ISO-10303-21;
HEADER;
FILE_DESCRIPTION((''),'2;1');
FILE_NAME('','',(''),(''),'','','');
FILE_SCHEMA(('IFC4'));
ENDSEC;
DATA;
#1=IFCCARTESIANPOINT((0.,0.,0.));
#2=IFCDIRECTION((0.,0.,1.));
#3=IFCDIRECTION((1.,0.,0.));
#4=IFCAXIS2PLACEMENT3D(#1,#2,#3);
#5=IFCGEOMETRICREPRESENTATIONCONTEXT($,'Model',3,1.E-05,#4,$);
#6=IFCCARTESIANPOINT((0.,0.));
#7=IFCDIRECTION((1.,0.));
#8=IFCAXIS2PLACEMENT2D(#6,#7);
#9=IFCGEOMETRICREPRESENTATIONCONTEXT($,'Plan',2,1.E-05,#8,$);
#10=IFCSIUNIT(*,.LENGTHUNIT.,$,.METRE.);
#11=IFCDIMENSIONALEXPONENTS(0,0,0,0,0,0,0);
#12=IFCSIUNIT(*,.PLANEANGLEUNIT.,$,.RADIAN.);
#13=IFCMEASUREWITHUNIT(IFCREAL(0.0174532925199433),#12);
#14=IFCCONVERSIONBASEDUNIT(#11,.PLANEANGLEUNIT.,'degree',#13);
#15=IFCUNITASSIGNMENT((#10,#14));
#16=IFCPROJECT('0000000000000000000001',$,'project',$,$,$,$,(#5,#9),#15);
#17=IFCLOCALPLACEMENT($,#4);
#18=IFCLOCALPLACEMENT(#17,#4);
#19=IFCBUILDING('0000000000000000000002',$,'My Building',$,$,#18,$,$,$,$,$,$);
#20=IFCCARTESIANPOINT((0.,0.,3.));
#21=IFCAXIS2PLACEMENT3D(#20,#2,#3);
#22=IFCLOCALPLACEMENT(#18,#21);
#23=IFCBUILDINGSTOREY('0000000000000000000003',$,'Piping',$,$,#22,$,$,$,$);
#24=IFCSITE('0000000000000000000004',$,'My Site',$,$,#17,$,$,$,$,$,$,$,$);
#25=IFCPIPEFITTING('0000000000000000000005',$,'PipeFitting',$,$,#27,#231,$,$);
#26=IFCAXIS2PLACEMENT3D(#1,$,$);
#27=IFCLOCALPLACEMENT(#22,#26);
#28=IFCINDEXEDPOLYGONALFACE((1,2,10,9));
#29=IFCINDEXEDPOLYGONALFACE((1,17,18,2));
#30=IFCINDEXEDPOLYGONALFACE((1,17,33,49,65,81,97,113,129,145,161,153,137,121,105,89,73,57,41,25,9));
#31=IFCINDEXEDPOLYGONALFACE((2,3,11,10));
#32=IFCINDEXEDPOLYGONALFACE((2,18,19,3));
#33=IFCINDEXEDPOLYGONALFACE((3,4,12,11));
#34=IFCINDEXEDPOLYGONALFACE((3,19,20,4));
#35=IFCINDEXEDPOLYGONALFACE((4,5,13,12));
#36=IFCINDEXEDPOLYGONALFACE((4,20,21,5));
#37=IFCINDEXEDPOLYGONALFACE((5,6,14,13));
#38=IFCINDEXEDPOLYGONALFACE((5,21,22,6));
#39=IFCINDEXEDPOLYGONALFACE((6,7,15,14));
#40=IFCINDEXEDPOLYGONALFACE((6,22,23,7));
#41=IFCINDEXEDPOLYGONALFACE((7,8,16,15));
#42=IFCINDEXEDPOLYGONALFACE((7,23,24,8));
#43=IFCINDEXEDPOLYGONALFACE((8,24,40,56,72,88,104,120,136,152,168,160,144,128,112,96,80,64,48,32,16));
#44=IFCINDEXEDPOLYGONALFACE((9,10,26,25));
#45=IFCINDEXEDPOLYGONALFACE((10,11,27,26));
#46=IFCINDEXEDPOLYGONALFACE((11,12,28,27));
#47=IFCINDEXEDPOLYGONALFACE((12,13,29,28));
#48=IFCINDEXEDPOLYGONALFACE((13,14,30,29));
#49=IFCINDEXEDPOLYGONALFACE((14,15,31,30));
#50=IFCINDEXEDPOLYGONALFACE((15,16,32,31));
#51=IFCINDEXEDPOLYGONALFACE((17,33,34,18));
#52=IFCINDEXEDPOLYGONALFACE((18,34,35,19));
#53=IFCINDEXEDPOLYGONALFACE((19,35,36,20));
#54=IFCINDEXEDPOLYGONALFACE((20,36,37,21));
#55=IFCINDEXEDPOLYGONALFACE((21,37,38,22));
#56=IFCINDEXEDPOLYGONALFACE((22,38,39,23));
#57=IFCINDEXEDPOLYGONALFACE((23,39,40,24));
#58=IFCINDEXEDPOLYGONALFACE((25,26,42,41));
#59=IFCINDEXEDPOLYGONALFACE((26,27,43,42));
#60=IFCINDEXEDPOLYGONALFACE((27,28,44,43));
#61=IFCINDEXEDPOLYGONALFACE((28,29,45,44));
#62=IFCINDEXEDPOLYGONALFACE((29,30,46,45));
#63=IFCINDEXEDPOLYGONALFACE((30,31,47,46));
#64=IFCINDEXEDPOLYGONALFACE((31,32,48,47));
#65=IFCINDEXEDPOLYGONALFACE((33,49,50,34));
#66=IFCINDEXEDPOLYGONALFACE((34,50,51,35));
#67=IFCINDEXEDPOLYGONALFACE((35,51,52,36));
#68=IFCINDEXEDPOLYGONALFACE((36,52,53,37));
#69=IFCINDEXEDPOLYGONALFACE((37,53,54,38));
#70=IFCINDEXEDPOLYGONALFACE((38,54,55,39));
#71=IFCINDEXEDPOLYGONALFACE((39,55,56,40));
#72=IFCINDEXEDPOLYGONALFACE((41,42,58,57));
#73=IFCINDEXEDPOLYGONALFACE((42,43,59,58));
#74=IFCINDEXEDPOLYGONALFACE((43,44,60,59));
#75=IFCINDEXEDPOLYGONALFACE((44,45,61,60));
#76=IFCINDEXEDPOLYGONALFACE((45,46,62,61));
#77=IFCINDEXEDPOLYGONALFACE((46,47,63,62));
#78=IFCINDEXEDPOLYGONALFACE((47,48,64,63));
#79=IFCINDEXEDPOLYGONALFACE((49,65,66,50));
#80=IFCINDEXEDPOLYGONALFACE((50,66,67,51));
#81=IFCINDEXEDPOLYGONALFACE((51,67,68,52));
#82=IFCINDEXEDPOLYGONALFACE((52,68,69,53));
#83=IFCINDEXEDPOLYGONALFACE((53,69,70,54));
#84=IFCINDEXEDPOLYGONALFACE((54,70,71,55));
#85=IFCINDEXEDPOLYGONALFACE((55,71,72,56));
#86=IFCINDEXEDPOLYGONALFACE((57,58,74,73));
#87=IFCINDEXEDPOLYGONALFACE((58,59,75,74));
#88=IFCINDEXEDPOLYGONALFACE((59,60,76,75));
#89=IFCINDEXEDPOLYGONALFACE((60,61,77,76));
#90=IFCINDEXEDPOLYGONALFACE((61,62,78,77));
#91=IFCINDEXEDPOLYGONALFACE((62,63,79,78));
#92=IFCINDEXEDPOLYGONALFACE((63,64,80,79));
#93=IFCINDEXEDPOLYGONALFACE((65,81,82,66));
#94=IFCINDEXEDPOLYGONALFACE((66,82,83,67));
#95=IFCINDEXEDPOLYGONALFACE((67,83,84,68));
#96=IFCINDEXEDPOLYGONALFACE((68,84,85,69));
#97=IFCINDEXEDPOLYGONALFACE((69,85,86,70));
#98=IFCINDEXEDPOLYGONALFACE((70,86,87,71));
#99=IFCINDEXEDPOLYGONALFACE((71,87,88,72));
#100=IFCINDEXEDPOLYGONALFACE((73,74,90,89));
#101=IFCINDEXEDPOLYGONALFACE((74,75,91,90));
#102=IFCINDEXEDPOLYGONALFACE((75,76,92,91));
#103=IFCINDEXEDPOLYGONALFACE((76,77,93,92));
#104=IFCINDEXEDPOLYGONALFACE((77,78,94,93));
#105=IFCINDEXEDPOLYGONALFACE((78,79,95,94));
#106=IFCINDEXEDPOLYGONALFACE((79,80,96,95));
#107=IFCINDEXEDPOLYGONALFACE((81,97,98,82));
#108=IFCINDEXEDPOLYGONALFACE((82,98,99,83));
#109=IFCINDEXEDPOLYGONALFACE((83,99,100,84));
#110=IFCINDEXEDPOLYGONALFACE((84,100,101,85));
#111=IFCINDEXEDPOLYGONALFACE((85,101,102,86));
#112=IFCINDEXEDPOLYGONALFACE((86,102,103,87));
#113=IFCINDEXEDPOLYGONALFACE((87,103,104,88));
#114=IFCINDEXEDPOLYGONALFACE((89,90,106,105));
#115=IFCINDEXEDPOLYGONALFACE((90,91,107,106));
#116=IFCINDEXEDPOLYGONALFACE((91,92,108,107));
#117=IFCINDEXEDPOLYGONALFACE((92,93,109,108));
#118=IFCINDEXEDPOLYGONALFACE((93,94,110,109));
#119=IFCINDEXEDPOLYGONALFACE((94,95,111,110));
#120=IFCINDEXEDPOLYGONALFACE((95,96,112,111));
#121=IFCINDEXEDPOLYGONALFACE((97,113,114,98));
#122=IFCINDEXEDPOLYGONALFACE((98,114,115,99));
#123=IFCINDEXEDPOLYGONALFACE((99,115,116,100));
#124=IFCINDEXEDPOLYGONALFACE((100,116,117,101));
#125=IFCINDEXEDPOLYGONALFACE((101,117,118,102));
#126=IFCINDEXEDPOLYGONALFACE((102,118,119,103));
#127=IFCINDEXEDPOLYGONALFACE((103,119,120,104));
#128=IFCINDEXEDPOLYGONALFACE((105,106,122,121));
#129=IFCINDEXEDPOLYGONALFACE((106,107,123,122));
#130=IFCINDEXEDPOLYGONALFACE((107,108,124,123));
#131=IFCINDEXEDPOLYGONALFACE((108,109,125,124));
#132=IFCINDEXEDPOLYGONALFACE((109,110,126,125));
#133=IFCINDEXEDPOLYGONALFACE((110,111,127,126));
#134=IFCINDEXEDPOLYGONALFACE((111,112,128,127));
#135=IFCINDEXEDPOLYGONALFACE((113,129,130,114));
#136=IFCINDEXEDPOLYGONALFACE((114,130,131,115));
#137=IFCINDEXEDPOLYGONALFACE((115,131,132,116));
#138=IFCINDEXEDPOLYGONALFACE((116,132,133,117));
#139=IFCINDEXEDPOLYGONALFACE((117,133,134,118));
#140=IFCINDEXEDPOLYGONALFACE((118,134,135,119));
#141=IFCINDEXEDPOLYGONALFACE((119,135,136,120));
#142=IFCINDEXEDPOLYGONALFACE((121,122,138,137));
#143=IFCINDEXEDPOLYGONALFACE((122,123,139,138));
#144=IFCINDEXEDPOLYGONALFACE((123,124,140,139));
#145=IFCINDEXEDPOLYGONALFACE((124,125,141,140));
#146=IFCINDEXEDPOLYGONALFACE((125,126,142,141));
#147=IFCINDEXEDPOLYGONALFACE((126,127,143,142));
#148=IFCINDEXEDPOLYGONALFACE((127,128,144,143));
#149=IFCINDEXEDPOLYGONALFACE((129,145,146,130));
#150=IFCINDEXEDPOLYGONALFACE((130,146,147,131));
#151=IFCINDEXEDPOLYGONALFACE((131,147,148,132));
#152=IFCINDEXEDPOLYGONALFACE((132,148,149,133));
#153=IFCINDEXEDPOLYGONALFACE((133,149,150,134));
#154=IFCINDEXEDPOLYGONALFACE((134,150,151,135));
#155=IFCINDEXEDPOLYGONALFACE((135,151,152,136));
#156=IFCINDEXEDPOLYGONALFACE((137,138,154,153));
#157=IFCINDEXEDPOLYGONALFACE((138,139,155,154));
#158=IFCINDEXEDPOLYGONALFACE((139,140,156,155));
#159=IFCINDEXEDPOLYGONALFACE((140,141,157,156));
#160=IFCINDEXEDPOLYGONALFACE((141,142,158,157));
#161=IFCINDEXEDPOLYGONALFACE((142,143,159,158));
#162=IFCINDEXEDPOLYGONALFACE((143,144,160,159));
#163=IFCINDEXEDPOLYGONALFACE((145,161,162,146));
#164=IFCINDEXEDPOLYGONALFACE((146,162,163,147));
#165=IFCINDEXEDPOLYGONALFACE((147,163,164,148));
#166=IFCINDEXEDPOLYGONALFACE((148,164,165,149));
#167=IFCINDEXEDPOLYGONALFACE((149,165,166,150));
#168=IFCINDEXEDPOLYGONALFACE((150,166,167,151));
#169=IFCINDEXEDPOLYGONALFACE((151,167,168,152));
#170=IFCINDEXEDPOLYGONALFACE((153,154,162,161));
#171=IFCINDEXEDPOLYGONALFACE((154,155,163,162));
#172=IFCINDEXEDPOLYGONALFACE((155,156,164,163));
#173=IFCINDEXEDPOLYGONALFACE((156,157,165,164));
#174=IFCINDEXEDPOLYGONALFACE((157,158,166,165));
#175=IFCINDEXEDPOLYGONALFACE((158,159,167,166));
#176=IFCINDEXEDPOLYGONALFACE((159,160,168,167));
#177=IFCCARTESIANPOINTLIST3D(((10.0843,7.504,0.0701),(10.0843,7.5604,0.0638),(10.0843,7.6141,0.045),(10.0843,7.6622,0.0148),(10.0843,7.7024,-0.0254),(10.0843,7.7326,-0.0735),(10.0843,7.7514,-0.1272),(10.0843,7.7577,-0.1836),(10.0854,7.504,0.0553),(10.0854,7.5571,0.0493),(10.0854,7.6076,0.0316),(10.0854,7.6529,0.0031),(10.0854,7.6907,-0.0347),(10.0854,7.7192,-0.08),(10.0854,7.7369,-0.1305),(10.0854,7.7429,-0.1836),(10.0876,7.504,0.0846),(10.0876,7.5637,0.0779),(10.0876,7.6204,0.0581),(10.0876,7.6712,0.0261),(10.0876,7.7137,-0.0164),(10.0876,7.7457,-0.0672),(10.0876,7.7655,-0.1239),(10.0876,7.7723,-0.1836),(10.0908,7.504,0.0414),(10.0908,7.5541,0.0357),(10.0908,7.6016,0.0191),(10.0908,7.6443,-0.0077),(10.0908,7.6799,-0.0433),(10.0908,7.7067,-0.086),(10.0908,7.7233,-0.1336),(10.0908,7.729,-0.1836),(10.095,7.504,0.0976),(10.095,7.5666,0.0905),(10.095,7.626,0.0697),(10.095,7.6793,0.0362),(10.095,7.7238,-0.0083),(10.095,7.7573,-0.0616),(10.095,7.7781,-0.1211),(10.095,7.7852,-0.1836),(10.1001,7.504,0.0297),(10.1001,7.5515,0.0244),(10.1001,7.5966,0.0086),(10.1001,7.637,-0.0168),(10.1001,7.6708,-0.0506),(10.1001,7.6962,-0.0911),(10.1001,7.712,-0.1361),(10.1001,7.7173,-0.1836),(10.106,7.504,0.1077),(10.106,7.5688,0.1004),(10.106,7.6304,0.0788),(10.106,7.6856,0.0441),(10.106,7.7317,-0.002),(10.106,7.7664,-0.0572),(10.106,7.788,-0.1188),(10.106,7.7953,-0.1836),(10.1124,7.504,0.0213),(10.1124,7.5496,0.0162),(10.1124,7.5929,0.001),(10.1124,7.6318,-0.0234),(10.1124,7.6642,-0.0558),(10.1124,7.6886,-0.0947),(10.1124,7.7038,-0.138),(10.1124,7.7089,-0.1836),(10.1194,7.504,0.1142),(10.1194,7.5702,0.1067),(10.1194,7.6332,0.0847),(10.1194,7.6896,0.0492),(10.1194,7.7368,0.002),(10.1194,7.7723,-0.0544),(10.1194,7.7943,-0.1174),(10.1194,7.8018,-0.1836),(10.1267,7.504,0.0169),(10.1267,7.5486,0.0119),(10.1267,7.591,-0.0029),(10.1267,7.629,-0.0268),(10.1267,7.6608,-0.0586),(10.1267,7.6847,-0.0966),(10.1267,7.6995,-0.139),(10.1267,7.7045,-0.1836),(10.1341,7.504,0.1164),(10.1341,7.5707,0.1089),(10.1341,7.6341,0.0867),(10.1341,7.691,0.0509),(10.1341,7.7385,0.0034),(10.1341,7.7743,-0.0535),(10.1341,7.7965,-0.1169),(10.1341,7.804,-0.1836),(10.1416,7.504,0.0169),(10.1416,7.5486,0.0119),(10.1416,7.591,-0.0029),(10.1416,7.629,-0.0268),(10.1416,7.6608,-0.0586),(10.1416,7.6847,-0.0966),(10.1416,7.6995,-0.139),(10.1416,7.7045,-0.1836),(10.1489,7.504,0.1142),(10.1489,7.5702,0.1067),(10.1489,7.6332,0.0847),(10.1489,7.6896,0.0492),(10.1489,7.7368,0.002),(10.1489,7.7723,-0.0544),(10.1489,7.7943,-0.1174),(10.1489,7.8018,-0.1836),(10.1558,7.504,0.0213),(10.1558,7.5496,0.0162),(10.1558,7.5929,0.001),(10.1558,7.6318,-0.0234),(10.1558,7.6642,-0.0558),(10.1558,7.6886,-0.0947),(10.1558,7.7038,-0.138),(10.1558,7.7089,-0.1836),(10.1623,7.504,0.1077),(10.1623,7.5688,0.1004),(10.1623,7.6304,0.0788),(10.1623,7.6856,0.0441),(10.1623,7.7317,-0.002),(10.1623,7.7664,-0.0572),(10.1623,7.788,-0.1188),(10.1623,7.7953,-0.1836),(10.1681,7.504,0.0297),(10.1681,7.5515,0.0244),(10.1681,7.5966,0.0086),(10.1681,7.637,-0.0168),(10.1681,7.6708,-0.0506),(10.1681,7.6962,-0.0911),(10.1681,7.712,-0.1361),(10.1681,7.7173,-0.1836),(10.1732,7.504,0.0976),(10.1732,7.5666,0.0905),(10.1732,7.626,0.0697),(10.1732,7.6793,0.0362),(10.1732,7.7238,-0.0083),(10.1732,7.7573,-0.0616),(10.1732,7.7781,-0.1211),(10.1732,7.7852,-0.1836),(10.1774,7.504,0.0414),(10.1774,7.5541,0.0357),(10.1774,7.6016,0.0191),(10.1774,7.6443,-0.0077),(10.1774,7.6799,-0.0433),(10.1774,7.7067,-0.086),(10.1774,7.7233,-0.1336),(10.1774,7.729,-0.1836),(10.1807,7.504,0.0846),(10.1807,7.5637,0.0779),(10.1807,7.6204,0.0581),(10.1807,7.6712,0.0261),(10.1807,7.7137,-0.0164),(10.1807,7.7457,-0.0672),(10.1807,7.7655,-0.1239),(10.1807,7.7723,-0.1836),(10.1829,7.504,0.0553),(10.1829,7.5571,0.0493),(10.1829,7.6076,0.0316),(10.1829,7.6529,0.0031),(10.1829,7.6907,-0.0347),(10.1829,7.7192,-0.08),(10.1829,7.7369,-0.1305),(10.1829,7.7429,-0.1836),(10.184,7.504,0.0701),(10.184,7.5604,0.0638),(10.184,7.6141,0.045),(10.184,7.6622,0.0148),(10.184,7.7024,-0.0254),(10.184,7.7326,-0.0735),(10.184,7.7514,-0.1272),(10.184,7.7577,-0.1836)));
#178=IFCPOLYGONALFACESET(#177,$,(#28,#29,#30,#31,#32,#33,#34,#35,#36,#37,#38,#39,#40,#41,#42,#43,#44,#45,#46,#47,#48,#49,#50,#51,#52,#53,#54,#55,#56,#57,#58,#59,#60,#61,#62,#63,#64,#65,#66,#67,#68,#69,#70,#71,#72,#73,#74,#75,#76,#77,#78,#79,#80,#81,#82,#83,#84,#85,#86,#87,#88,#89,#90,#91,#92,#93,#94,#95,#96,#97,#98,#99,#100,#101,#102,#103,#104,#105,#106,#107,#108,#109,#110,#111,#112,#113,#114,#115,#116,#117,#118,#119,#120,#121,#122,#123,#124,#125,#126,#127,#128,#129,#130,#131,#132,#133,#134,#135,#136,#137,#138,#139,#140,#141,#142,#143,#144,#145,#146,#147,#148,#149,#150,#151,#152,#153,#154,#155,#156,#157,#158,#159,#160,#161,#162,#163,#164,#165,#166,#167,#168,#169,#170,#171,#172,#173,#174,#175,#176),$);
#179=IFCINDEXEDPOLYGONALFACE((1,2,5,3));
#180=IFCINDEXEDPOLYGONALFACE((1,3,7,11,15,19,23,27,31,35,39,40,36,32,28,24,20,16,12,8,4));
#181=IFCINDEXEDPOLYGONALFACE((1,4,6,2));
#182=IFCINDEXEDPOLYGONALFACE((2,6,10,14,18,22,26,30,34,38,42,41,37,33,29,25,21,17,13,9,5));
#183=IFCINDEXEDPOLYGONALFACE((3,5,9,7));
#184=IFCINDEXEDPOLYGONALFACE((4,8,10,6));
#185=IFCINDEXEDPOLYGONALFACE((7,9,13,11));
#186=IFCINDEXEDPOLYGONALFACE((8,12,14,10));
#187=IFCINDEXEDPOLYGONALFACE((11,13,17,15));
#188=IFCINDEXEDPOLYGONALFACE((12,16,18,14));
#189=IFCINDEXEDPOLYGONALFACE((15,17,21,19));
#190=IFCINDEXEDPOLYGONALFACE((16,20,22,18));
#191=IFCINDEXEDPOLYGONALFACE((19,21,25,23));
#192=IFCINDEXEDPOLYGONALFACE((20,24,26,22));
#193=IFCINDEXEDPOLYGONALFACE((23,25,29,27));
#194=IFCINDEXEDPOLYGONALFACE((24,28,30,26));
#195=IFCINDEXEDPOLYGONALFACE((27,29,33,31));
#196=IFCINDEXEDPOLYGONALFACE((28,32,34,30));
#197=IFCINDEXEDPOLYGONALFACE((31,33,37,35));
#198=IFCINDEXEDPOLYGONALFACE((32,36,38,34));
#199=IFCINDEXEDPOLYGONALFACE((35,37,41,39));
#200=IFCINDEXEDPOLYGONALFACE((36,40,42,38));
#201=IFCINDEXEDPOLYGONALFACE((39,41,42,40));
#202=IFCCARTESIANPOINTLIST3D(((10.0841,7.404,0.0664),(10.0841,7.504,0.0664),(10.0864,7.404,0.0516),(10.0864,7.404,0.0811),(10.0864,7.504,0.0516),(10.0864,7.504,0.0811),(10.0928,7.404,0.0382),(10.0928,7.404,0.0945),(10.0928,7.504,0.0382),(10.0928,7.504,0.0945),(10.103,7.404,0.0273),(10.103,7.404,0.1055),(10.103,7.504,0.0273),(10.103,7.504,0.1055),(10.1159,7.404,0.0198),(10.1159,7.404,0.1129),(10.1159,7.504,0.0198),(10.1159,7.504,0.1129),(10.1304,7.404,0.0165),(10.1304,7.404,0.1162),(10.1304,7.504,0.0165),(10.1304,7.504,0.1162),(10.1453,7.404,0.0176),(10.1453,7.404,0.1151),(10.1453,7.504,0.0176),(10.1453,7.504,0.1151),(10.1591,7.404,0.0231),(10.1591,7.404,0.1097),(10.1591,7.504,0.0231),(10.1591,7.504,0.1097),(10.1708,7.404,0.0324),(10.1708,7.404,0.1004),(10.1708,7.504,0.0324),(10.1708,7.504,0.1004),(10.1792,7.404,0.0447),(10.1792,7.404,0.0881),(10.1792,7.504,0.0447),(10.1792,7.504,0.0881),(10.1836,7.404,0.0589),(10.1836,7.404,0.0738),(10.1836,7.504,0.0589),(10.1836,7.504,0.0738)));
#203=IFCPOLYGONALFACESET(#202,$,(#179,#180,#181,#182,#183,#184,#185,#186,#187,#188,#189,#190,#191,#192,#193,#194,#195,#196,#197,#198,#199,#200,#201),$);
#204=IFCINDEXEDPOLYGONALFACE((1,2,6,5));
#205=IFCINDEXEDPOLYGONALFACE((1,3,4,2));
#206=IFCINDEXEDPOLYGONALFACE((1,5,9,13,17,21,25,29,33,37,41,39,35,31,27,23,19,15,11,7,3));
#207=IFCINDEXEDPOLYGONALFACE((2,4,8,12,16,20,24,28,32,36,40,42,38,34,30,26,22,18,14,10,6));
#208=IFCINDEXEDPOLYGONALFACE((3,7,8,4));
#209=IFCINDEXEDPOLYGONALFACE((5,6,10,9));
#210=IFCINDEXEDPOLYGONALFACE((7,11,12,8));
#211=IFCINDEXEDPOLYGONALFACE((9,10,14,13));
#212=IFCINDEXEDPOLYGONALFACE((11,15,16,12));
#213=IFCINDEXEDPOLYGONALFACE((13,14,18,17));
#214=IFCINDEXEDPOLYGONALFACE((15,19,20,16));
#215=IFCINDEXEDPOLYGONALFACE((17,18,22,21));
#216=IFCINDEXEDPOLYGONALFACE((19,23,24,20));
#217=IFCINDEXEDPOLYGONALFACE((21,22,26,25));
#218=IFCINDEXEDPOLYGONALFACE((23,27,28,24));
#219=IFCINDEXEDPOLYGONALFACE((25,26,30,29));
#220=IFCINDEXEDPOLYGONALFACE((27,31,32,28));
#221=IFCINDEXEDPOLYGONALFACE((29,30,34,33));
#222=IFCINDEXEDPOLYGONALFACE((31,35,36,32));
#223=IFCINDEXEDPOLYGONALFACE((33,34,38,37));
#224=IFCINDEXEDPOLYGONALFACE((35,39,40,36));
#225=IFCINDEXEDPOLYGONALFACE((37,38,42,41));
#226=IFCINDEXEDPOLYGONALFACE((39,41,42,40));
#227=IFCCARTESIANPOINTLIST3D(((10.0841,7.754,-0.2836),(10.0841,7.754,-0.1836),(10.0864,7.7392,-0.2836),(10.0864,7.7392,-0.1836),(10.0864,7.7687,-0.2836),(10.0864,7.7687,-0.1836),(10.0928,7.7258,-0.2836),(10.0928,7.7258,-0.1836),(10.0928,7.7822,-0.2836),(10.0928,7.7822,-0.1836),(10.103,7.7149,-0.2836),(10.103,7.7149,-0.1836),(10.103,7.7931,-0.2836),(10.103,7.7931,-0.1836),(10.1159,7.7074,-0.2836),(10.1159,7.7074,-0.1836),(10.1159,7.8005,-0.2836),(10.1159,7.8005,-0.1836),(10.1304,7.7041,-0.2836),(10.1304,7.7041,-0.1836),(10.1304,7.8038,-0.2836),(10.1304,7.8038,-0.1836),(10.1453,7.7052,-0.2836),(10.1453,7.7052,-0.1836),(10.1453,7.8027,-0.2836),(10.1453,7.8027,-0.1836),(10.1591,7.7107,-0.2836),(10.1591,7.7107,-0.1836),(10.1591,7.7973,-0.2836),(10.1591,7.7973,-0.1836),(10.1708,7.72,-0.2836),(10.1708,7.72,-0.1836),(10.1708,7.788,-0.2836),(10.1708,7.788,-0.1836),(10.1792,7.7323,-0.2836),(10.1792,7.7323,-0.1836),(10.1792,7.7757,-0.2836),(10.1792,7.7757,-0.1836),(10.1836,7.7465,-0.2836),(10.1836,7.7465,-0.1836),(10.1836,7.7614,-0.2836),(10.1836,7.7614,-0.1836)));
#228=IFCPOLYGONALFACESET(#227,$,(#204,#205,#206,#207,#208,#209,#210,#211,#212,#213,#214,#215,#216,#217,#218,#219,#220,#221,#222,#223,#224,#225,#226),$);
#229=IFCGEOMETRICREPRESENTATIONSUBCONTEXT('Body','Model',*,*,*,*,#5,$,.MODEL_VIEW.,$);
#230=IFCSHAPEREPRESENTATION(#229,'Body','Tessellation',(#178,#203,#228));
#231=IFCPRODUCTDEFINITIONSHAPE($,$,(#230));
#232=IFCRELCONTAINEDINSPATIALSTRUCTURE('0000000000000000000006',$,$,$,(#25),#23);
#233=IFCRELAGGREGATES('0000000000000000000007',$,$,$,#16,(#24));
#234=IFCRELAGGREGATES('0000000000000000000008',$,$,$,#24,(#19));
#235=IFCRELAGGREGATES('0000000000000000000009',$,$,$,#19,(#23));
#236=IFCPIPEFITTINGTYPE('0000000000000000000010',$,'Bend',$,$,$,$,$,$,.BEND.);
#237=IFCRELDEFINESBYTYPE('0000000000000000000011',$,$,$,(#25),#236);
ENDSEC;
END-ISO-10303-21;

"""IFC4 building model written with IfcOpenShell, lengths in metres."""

from ifc_helpers import new_model, entity, si_unit, converted_unit, frame, origin_with_axes, origin_2d_with_axis, place, context, subcontext, project, spatial, circle, extrude, source, transform, mapped, type_object, type_shapes, element, save


model = new_model("IFC4")

# Units and contexts
model_context = context("Model", 3, precision=1e-05, world=origin_with_axes())
plan_context = context("Plan", 2, precision=1e-05, world=origin_2d_with_axis())
body_context = subcontext(model_context, "Body", "Model", "MODEL_VIEW")
ifc_project = project(units=[si_unit("LENGTHUNIT", "METRE"), converted_unit("PLANEANGLEUNIT", "degree", entity("IfcReal", 0.0174532925199433), si_unit("PLANEANGLEUNIT", "RADIAN"), dimensions=[0, 0, 0, 0, 0, 0, 0])], contexts=[model_context, plan_context])

# Site, building, storey
site_placement = place(None, origin_with_axes())
site = spatial("IfcSite", under=ifc_project, at=site_placement, Name="My Site")
building_placement = place(site_placement, origin_with_axes())
building = spatial("IfcBuilding", under=site, at=building_placement, Name="My Building")
storey_placement = place(building_placement, frame((0.0, 0.0, 3.0), z_axis=(0.0, 0.0, 1.0), x_axis=(1.0, 0.0, 0.0)))
storey = spatial("IfcBuildingStorey", under=building, at=storey_placement, Name="Piping")

# Pipe fitting
pipe_fitting_type_1 = type_object("IfcPipeFittingType", Name="Bend", PredefinedType="BEND")
shared_shape = source(origin_with_axes(), body_context, "Body", "SolidModel", [
    entity("IfcSweptDiskSolid", entity("IfcIndexedPolyCurve", entity("IfcCartesianPointList3D", [[0.0, 0.0, 0.1], [0.0, -0.0732, 0.2768], [0.0, -0.25, 0.35]]), [entity("IfcArcIndex", [1, 2, 3])]), 0.05),
    extrude(circle(Radius=0.05), origin_with_axes(), (0.0, 0.0, 1.0), 0.1),
    extrude(circle(Radius=0.05), frame((0.0, -0.25, 0.35), z_axis=(0.0, -1.0, -0.000002), x_axis=(1.0, 0.0, 0.0)), (0.0, 0.0, 1.0), 0.1),
])
type_shapes(pipe_fitting_type_1, [shared_shape])
for number, where, z_axis, x_axis, name in (
    (1, (10.1341, 7.404, 0.0664), (0.0, 1.0, 0.000002), (-1.0, 0.0, 0.0), "PipeFitting"),
):
    element("IfcPipeFitting", number, at=place(storey_placement, frame(where, z_axis=z_axis, x_axis=x_axis)), inside=storey, type_object=pipe_fitting_type_1, Name=name, context=body_context, shape_type="MappedRepresentation", body=[
        mapped(shared_shape, transform((0.0, 0.0, 0.0), x_axis=(1.0, 0.0, 0.0), y_axis=(0.0, 1.0, 0.0), z_axis=(0.0, 0.0, 1.0), scale=1.0)),
    ])

save(model, "model.ifc")
